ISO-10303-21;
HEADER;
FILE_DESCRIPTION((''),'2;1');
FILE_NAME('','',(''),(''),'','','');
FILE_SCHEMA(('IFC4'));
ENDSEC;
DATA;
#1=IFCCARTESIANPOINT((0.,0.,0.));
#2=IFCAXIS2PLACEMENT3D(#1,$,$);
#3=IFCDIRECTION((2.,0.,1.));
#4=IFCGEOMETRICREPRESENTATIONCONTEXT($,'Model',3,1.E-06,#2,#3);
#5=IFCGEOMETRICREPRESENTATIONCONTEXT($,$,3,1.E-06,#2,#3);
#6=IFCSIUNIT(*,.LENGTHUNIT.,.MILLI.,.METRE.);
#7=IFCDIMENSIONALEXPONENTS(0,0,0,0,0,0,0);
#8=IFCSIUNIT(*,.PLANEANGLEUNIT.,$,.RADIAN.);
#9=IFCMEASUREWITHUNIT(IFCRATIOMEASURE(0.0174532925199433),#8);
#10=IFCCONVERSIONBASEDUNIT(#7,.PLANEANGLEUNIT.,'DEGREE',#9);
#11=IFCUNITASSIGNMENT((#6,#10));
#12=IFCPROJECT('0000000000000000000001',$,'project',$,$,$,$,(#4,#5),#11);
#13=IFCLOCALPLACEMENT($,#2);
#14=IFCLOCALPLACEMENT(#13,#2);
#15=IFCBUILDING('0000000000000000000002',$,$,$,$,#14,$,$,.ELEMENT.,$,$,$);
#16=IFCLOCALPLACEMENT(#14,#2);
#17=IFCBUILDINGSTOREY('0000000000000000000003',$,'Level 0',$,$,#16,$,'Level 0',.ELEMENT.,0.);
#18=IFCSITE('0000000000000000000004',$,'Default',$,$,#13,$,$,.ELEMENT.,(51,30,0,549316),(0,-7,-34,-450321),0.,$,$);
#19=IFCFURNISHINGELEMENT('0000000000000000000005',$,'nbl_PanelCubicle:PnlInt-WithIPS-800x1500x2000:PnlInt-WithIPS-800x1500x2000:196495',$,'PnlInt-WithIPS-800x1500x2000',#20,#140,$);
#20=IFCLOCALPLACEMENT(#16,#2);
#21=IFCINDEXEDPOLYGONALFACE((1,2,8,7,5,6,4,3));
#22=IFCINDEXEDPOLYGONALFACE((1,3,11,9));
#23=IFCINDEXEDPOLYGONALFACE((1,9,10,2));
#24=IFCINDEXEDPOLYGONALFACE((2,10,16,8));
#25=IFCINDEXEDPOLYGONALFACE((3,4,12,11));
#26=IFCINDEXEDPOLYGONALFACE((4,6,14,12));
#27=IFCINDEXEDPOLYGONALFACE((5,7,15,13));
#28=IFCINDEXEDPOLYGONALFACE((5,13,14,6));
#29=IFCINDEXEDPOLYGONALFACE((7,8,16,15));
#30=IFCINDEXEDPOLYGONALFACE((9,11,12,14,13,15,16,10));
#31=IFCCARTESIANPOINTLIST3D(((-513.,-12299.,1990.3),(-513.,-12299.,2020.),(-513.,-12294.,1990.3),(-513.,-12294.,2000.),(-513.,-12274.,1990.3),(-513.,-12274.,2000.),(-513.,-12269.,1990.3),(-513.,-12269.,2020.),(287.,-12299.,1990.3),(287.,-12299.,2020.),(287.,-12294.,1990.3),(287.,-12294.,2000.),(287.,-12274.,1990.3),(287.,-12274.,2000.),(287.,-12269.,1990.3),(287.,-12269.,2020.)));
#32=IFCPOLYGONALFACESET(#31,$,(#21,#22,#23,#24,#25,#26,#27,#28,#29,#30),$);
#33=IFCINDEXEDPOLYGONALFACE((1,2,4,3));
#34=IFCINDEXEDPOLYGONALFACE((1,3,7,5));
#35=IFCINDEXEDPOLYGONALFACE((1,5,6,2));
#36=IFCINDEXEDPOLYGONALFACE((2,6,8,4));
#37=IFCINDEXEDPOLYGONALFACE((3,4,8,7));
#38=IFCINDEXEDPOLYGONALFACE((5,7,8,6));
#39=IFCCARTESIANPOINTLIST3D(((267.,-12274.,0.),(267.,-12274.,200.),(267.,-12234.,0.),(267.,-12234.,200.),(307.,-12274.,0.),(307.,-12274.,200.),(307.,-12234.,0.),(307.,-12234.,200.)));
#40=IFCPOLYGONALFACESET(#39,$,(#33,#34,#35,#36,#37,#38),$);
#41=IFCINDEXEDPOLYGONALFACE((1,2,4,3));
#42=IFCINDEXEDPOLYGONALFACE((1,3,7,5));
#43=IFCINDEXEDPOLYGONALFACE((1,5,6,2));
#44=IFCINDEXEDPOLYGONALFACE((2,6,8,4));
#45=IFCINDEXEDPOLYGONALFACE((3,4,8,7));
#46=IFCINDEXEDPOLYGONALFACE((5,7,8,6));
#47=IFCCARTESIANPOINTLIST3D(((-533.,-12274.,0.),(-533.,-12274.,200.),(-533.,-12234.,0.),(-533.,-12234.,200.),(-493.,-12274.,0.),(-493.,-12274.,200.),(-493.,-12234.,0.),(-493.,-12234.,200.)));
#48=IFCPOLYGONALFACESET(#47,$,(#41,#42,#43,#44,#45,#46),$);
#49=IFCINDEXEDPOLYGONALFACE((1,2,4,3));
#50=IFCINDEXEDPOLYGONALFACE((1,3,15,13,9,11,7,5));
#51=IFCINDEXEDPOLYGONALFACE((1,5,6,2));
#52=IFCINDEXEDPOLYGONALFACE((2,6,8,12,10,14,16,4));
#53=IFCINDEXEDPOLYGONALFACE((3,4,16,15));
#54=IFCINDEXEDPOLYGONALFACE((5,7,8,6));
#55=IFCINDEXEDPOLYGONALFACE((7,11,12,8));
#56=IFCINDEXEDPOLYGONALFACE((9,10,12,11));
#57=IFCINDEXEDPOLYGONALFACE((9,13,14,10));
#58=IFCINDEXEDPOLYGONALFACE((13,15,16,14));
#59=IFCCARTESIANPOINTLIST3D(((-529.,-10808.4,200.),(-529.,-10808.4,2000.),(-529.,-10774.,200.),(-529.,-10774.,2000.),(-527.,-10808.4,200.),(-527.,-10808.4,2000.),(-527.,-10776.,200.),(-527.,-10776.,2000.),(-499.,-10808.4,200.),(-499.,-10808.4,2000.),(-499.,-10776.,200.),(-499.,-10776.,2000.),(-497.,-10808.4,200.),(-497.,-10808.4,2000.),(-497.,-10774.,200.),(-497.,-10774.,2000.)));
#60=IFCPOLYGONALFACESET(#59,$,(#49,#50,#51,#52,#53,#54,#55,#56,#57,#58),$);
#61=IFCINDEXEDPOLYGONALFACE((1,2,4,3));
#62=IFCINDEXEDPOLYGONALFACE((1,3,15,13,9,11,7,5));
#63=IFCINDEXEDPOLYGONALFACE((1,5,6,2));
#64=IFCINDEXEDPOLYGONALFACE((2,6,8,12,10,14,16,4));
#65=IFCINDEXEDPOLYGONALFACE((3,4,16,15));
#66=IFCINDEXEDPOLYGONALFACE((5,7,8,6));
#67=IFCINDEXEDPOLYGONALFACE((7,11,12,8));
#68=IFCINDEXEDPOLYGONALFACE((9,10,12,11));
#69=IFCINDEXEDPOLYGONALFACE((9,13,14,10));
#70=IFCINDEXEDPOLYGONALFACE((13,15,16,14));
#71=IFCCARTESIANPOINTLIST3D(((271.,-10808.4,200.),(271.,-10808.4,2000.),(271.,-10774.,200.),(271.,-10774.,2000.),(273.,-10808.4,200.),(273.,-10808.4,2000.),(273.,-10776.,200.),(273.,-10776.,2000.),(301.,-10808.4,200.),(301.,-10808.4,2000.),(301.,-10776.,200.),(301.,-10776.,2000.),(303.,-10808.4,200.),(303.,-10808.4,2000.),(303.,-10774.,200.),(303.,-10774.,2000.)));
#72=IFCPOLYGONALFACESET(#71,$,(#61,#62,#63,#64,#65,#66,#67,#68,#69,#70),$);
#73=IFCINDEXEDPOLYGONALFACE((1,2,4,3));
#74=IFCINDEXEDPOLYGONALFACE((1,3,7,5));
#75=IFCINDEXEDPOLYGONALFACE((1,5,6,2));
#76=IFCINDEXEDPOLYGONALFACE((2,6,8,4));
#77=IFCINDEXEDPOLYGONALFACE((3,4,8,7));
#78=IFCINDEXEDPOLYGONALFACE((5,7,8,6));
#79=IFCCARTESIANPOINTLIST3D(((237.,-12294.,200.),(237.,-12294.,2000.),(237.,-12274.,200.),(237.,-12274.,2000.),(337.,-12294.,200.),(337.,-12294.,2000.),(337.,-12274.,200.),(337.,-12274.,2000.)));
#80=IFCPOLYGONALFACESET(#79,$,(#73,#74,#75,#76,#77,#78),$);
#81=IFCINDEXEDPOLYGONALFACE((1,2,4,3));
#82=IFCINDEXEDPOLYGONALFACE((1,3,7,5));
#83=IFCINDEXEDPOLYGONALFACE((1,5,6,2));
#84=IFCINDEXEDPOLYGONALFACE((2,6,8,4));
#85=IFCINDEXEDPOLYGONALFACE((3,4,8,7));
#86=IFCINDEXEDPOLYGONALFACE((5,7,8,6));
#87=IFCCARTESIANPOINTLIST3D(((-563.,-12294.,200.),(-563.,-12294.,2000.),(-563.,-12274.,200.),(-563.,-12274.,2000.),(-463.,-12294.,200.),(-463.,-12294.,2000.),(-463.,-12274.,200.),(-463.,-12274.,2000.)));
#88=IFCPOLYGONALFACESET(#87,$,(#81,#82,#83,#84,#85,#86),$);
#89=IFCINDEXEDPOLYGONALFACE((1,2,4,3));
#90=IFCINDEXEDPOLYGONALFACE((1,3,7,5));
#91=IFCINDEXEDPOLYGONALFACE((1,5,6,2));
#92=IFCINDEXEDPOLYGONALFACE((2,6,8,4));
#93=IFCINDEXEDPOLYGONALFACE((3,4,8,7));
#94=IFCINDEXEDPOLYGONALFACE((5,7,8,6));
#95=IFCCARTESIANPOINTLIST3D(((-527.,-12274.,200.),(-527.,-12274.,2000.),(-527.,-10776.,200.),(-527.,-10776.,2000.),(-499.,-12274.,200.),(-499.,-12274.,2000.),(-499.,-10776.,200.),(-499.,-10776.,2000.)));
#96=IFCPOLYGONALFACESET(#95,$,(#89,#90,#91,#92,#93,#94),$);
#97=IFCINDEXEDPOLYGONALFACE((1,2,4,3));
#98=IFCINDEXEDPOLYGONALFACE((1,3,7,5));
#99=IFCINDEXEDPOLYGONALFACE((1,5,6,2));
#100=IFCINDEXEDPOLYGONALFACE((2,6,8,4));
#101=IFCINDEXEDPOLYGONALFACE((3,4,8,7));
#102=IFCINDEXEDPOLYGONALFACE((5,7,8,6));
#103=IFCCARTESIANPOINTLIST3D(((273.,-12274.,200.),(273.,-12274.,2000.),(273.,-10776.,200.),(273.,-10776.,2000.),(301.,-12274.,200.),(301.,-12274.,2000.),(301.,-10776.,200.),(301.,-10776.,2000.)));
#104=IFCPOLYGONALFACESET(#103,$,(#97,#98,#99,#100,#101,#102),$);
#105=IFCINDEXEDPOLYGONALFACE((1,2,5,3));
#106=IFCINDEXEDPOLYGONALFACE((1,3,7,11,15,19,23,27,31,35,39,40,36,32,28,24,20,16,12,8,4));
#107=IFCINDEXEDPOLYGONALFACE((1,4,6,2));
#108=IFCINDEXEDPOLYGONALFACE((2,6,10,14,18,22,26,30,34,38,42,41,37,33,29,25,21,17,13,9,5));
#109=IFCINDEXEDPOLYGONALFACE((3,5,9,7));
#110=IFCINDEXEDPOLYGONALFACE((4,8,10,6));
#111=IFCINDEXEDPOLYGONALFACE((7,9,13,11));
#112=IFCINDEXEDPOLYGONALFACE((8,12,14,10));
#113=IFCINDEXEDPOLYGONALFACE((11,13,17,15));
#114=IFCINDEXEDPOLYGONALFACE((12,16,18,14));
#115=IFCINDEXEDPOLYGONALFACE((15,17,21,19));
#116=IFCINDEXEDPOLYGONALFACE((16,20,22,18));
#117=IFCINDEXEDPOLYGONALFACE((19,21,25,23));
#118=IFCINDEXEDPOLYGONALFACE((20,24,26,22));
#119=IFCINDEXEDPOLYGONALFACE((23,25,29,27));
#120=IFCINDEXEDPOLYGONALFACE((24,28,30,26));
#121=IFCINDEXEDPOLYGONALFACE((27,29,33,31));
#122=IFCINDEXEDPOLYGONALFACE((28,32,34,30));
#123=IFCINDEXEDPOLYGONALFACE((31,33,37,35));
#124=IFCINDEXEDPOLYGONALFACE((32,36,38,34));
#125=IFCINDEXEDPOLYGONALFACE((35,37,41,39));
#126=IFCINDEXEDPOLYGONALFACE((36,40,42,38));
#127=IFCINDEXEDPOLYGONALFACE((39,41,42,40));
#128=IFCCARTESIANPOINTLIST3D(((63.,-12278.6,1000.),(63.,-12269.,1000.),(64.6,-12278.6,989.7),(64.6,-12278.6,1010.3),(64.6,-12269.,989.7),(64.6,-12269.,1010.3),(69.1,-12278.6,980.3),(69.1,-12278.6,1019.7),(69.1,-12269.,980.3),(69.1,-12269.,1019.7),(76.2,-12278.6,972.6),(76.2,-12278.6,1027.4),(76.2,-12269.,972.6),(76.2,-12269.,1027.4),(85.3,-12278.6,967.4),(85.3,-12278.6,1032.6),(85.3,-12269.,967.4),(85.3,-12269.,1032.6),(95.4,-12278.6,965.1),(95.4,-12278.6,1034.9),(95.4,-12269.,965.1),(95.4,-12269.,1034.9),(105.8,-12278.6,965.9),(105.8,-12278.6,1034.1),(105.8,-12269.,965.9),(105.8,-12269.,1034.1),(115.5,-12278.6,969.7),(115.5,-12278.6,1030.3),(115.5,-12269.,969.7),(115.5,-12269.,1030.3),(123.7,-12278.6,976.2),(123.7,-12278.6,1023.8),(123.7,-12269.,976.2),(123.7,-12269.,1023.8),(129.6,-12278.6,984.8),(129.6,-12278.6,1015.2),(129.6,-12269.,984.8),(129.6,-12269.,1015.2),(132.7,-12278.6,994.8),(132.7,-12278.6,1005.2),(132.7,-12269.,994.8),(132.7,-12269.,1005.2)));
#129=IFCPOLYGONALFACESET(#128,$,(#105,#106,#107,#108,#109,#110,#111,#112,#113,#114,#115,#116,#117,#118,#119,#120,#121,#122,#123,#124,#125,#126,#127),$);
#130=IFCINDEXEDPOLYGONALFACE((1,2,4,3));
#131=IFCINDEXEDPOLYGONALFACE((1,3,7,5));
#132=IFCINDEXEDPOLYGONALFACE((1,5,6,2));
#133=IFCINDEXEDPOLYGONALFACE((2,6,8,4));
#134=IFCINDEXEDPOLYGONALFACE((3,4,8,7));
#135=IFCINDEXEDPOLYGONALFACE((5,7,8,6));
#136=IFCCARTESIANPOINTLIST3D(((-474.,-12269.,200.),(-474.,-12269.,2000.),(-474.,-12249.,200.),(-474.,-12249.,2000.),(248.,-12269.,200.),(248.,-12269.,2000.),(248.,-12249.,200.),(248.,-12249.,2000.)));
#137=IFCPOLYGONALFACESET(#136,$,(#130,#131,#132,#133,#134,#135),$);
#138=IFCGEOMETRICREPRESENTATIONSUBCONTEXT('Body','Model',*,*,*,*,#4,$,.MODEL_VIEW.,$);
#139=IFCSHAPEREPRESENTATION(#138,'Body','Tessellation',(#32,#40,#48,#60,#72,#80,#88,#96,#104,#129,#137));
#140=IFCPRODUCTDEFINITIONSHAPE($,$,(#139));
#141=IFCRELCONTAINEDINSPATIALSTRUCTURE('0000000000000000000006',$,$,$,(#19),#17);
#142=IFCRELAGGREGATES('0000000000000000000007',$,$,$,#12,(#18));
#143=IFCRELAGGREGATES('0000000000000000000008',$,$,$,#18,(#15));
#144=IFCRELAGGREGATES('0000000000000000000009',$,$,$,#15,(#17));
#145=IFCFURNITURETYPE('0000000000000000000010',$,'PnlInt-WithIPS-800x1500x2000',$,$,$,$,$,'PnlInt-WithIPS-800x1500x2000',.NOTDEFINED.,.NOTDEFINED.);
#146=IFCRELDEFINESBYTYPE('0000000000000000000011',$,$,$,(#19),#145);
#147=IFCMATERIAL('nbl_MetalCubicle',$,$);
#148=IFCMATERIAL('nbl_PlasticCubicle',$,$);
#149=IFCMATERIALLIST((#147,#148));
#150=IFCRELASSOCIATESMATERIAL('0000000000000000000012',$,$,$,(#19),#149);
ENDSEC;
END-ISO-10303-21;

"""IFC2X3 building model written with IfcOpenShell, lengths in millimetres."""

from ifc_helpers import new_model, entity, si_unit, converted_unit, direction, frame, frame_2d, origin, origin_2d_with_axis, place, context, subcontext, project, spatial, polyline, rectangle, circle, outline, extrude, source, transform, mapped, material, material_list, type_object, type_shapes, element, save


model = new_model("IFC2X3")

# Units and contexts
model_context = context("Model", 3, precision=1e-06, world=origin(), true_north=direction((2.0, 0.0, 1.0)))
context_of_model = context(None, 3, precision=1e-06, world=origin(), true_north=direction((2.0, 0.0, 1.0)))
body_context = subcontext(model_context, "Body", "Model", "MODEL_VIEW")
ifc_project = project(units=[si_unit("LENGTHUNIT", "METRE", prefix="MILLI"), converted_unit("PLANEANGLEUNIT", "DEGREE", entity("IfcRatioMeasure", 0.0174532925199433), si_unit("PLANEANGLEUNIT", "RADIAN"), dimensions=[0, 0, 0, 0, 0, 0, 0])], contexts=[model_context, context_of_model])

# Site, building, storey
site_placement = place(None, origin())
site = spatial("IfcSite", under=ifc_project, at=site_placement, Name="Default", CompositionType="ELEMENT", RefLatitude=(51, 30, 0, 549316), RefLongitude=(0, -7, -34, -450321), RefElevation=0.0)
building_placement = place(site_placement, origin())
building = spatial("IfcBuilding", under=site, at=building_placement, CompositionType="ELEMENT")
storey_placement = place(building_placement, origin())
storey = spatial("IfcBuildingStorey", under=building, at=storey_placement, Name="Level 0", LongName="Level 0", CompositionType="ELEMENT", Elevation=0.0)

# Furnishing element
ifc_material_1 = material(Name="nbl_MetalCubicle")
ifc_material_2 = material(Name="nbl_PlasticCubicle")
ifc_material_list_1 = material_list([ifc_material_1, ifc_material_2])
furniture_type_1 = type_object("IfcFurnitureType", Name="PnlInt-WithIPS-800x1500x2000", ElementType="PnlInt-WithIPS-800x1500x2000", AssemblyPlace="NOTDEFINED")
shared_shape_1 = source(origin(), body_context, "Body", "SweptSolid", [
    extrude(outline(polyline([(-19.8, -15.0), (9.8, -15.0), (9.8, -10.0), (0.2, -10.0), (0.2, 10.0), (9.8, 10.0), (9.8, 15.0), (-19.8, 15.0), (-19.8, -15.0)])), frame((-275.0, 1560.0, 2000.2), z_axis=(1.0, 0.0, 0.0), x_axis=(0.0, 0.0, -1.0)), (0.0, 0.0, 1.0), 800.0),
    extrude(rectangle(XDim=40.0, YDim=40.0, at=frame_2d((0.0, 0.0), x_axis=(1.0, 0.0))), frame((-275.0, 1530.0, 0.0), z_axis=(0.0, 0.0, 1.0), x_axis=(0.0, 1.0, 0.0)), (0.0, 0.0, 1.0), 200.0),
    extrude(rectangle(XDim=40.0, YDim=40.0, at=frame_2d((0.0, 0.0), x_axis=(1.0, 0.0))), frame((525.0, 1530.0, 0.0), z_axis=(0.0, 0.0, 1.0), x_axis=(0.0, 1.0, 0.0)), (0.0, 0.0, 1.0), 200.0),
    extrude(outline(polyline([(14.0, -16.7), (16.0, -16.7), (16.0, 17.7), (-16.0, 17.7), (-16.0, -16.7), (-14.0, -16.7), (-14.0, 15.7), (14.0, 15.7), (14.0, -16.7)])), frame((525.0, 67.7, 200.0), z_axis=(0.0, 0.0, 1.0), x_axis=(-1.0, 0.0, 0.0)), (0.0, 0.0, 1.0), 1800.0),
    extrude(outline(polyline([(-16.7, -16.0), (17.7, -16.0), (17.7, 16.0), (-16.7, 16.0), (-16.7, 14.0), (15.7, 14.0), (15.7, -14.0), (-16.7, -14.0), (-16.7, -16.0)])), frame((-275.0, 67.7, 200.0), z_axis=(0.0, 0.0, 1.0), x_axis=(0.0, -1.0, 0.0)), (0.0, 0.0, 1.0), 1800.0),
    extrude(rectangle(XDim=100.0, YDim=20.0, at=frame_2d((0.0, 0.0), x_axis=(1.0, 0.0))), frame((-275.0, 1560.0, 200.0), z_axis=(0.0, 0.0, 1.0), x_axis=(-1.0, 0.0, 0.0)), (0.0, 0.0, 1.0), 1800.0),
    extrude(rectangle(XDim=100.0, YDim=20.0, at=frame_2d((0.0, 0.0), x_axis=(1.0, 0.0))), frame((525.0, 1560.0, 200.0), z_axis=(0.0, 0.0, 1.0), x_axis=(-1.0, 0.0, 0.0)), (0.0, 0.0, 1.0), 1800.0),
    extrude(rectangle(XDim=28.0, YDim=1498.0, at=frame_2d((0.0, 0.0), x_axis=(1.0, 0.0))), frame((525.0, 801.0, 200.0), z_axis=(0.0, 0.0, 1.0), x_axis=(-1.0, 0.0, 0.0)), (0.0, 0.0, 1.0), 1800.0),
    extrude(rectangle(XDim=28.0, YDim=1498.0, at=frame_2d((0.0, 0.0), x_axis=(1.0, 0.0))), frame((-275.0, 801.0, 200.0), z_axis=(0.0, 0.0, 1.0), x_axis=(-1.0, 0.0, 0.0)), (0.0, 0.0, 1.0), 1800.0),
    extrude(circle(Radius=35.0, at=frame_2d((0.0, 0.0), x_axis=(1.0, 0.0))), frame((-86.0, 1545.0, 1000.0), z_axis=(0.0, 1.0, 0.0), x_axis=(1.0, 0.0, 0.0)), (0.0, 0.0, 1.0), 9.7),
    extrude(rectangle(XDim=722.0, YDim=20.0, at=origin_2d_with_axis()), frame((125.0, 1535.0, 200.0), z_axis=(0.0, 0.0, 1.0), x_axis=(-1.0, 0.0, 0.0)), (0.0, 0.0, 1.0), 1800.0),
])
type_shapes(furniture_type_1, [shared_shape_1])
furnishing_1_placement = place(storey_placement, frame((12.0, -10724.0, 0.0), z_axis=(0.0, 0.0, 1.0), x_axis=(-1.0, 0.0, 0.0)))
element("IfcFurnishingElement", 1, at=furnishing_1_placement, inside=storey, type_object=furniture_type_1, material=ifc_material_list_1, Name="nbl_PanelCubicle:PnlInt-WithIPS-800x1500x2000:PnlInt-WithIPS-800x1500x2000:196495", ObjectType="PnlInt-WithIPS-800x1500x2000", context=body_context, shape_type="MappedRepresentation", body=[
    mapped(shared_shape_1, transform((0.0, 0.0, 0.0), scale=1.0)),
])

save(model, "model.ifc")
